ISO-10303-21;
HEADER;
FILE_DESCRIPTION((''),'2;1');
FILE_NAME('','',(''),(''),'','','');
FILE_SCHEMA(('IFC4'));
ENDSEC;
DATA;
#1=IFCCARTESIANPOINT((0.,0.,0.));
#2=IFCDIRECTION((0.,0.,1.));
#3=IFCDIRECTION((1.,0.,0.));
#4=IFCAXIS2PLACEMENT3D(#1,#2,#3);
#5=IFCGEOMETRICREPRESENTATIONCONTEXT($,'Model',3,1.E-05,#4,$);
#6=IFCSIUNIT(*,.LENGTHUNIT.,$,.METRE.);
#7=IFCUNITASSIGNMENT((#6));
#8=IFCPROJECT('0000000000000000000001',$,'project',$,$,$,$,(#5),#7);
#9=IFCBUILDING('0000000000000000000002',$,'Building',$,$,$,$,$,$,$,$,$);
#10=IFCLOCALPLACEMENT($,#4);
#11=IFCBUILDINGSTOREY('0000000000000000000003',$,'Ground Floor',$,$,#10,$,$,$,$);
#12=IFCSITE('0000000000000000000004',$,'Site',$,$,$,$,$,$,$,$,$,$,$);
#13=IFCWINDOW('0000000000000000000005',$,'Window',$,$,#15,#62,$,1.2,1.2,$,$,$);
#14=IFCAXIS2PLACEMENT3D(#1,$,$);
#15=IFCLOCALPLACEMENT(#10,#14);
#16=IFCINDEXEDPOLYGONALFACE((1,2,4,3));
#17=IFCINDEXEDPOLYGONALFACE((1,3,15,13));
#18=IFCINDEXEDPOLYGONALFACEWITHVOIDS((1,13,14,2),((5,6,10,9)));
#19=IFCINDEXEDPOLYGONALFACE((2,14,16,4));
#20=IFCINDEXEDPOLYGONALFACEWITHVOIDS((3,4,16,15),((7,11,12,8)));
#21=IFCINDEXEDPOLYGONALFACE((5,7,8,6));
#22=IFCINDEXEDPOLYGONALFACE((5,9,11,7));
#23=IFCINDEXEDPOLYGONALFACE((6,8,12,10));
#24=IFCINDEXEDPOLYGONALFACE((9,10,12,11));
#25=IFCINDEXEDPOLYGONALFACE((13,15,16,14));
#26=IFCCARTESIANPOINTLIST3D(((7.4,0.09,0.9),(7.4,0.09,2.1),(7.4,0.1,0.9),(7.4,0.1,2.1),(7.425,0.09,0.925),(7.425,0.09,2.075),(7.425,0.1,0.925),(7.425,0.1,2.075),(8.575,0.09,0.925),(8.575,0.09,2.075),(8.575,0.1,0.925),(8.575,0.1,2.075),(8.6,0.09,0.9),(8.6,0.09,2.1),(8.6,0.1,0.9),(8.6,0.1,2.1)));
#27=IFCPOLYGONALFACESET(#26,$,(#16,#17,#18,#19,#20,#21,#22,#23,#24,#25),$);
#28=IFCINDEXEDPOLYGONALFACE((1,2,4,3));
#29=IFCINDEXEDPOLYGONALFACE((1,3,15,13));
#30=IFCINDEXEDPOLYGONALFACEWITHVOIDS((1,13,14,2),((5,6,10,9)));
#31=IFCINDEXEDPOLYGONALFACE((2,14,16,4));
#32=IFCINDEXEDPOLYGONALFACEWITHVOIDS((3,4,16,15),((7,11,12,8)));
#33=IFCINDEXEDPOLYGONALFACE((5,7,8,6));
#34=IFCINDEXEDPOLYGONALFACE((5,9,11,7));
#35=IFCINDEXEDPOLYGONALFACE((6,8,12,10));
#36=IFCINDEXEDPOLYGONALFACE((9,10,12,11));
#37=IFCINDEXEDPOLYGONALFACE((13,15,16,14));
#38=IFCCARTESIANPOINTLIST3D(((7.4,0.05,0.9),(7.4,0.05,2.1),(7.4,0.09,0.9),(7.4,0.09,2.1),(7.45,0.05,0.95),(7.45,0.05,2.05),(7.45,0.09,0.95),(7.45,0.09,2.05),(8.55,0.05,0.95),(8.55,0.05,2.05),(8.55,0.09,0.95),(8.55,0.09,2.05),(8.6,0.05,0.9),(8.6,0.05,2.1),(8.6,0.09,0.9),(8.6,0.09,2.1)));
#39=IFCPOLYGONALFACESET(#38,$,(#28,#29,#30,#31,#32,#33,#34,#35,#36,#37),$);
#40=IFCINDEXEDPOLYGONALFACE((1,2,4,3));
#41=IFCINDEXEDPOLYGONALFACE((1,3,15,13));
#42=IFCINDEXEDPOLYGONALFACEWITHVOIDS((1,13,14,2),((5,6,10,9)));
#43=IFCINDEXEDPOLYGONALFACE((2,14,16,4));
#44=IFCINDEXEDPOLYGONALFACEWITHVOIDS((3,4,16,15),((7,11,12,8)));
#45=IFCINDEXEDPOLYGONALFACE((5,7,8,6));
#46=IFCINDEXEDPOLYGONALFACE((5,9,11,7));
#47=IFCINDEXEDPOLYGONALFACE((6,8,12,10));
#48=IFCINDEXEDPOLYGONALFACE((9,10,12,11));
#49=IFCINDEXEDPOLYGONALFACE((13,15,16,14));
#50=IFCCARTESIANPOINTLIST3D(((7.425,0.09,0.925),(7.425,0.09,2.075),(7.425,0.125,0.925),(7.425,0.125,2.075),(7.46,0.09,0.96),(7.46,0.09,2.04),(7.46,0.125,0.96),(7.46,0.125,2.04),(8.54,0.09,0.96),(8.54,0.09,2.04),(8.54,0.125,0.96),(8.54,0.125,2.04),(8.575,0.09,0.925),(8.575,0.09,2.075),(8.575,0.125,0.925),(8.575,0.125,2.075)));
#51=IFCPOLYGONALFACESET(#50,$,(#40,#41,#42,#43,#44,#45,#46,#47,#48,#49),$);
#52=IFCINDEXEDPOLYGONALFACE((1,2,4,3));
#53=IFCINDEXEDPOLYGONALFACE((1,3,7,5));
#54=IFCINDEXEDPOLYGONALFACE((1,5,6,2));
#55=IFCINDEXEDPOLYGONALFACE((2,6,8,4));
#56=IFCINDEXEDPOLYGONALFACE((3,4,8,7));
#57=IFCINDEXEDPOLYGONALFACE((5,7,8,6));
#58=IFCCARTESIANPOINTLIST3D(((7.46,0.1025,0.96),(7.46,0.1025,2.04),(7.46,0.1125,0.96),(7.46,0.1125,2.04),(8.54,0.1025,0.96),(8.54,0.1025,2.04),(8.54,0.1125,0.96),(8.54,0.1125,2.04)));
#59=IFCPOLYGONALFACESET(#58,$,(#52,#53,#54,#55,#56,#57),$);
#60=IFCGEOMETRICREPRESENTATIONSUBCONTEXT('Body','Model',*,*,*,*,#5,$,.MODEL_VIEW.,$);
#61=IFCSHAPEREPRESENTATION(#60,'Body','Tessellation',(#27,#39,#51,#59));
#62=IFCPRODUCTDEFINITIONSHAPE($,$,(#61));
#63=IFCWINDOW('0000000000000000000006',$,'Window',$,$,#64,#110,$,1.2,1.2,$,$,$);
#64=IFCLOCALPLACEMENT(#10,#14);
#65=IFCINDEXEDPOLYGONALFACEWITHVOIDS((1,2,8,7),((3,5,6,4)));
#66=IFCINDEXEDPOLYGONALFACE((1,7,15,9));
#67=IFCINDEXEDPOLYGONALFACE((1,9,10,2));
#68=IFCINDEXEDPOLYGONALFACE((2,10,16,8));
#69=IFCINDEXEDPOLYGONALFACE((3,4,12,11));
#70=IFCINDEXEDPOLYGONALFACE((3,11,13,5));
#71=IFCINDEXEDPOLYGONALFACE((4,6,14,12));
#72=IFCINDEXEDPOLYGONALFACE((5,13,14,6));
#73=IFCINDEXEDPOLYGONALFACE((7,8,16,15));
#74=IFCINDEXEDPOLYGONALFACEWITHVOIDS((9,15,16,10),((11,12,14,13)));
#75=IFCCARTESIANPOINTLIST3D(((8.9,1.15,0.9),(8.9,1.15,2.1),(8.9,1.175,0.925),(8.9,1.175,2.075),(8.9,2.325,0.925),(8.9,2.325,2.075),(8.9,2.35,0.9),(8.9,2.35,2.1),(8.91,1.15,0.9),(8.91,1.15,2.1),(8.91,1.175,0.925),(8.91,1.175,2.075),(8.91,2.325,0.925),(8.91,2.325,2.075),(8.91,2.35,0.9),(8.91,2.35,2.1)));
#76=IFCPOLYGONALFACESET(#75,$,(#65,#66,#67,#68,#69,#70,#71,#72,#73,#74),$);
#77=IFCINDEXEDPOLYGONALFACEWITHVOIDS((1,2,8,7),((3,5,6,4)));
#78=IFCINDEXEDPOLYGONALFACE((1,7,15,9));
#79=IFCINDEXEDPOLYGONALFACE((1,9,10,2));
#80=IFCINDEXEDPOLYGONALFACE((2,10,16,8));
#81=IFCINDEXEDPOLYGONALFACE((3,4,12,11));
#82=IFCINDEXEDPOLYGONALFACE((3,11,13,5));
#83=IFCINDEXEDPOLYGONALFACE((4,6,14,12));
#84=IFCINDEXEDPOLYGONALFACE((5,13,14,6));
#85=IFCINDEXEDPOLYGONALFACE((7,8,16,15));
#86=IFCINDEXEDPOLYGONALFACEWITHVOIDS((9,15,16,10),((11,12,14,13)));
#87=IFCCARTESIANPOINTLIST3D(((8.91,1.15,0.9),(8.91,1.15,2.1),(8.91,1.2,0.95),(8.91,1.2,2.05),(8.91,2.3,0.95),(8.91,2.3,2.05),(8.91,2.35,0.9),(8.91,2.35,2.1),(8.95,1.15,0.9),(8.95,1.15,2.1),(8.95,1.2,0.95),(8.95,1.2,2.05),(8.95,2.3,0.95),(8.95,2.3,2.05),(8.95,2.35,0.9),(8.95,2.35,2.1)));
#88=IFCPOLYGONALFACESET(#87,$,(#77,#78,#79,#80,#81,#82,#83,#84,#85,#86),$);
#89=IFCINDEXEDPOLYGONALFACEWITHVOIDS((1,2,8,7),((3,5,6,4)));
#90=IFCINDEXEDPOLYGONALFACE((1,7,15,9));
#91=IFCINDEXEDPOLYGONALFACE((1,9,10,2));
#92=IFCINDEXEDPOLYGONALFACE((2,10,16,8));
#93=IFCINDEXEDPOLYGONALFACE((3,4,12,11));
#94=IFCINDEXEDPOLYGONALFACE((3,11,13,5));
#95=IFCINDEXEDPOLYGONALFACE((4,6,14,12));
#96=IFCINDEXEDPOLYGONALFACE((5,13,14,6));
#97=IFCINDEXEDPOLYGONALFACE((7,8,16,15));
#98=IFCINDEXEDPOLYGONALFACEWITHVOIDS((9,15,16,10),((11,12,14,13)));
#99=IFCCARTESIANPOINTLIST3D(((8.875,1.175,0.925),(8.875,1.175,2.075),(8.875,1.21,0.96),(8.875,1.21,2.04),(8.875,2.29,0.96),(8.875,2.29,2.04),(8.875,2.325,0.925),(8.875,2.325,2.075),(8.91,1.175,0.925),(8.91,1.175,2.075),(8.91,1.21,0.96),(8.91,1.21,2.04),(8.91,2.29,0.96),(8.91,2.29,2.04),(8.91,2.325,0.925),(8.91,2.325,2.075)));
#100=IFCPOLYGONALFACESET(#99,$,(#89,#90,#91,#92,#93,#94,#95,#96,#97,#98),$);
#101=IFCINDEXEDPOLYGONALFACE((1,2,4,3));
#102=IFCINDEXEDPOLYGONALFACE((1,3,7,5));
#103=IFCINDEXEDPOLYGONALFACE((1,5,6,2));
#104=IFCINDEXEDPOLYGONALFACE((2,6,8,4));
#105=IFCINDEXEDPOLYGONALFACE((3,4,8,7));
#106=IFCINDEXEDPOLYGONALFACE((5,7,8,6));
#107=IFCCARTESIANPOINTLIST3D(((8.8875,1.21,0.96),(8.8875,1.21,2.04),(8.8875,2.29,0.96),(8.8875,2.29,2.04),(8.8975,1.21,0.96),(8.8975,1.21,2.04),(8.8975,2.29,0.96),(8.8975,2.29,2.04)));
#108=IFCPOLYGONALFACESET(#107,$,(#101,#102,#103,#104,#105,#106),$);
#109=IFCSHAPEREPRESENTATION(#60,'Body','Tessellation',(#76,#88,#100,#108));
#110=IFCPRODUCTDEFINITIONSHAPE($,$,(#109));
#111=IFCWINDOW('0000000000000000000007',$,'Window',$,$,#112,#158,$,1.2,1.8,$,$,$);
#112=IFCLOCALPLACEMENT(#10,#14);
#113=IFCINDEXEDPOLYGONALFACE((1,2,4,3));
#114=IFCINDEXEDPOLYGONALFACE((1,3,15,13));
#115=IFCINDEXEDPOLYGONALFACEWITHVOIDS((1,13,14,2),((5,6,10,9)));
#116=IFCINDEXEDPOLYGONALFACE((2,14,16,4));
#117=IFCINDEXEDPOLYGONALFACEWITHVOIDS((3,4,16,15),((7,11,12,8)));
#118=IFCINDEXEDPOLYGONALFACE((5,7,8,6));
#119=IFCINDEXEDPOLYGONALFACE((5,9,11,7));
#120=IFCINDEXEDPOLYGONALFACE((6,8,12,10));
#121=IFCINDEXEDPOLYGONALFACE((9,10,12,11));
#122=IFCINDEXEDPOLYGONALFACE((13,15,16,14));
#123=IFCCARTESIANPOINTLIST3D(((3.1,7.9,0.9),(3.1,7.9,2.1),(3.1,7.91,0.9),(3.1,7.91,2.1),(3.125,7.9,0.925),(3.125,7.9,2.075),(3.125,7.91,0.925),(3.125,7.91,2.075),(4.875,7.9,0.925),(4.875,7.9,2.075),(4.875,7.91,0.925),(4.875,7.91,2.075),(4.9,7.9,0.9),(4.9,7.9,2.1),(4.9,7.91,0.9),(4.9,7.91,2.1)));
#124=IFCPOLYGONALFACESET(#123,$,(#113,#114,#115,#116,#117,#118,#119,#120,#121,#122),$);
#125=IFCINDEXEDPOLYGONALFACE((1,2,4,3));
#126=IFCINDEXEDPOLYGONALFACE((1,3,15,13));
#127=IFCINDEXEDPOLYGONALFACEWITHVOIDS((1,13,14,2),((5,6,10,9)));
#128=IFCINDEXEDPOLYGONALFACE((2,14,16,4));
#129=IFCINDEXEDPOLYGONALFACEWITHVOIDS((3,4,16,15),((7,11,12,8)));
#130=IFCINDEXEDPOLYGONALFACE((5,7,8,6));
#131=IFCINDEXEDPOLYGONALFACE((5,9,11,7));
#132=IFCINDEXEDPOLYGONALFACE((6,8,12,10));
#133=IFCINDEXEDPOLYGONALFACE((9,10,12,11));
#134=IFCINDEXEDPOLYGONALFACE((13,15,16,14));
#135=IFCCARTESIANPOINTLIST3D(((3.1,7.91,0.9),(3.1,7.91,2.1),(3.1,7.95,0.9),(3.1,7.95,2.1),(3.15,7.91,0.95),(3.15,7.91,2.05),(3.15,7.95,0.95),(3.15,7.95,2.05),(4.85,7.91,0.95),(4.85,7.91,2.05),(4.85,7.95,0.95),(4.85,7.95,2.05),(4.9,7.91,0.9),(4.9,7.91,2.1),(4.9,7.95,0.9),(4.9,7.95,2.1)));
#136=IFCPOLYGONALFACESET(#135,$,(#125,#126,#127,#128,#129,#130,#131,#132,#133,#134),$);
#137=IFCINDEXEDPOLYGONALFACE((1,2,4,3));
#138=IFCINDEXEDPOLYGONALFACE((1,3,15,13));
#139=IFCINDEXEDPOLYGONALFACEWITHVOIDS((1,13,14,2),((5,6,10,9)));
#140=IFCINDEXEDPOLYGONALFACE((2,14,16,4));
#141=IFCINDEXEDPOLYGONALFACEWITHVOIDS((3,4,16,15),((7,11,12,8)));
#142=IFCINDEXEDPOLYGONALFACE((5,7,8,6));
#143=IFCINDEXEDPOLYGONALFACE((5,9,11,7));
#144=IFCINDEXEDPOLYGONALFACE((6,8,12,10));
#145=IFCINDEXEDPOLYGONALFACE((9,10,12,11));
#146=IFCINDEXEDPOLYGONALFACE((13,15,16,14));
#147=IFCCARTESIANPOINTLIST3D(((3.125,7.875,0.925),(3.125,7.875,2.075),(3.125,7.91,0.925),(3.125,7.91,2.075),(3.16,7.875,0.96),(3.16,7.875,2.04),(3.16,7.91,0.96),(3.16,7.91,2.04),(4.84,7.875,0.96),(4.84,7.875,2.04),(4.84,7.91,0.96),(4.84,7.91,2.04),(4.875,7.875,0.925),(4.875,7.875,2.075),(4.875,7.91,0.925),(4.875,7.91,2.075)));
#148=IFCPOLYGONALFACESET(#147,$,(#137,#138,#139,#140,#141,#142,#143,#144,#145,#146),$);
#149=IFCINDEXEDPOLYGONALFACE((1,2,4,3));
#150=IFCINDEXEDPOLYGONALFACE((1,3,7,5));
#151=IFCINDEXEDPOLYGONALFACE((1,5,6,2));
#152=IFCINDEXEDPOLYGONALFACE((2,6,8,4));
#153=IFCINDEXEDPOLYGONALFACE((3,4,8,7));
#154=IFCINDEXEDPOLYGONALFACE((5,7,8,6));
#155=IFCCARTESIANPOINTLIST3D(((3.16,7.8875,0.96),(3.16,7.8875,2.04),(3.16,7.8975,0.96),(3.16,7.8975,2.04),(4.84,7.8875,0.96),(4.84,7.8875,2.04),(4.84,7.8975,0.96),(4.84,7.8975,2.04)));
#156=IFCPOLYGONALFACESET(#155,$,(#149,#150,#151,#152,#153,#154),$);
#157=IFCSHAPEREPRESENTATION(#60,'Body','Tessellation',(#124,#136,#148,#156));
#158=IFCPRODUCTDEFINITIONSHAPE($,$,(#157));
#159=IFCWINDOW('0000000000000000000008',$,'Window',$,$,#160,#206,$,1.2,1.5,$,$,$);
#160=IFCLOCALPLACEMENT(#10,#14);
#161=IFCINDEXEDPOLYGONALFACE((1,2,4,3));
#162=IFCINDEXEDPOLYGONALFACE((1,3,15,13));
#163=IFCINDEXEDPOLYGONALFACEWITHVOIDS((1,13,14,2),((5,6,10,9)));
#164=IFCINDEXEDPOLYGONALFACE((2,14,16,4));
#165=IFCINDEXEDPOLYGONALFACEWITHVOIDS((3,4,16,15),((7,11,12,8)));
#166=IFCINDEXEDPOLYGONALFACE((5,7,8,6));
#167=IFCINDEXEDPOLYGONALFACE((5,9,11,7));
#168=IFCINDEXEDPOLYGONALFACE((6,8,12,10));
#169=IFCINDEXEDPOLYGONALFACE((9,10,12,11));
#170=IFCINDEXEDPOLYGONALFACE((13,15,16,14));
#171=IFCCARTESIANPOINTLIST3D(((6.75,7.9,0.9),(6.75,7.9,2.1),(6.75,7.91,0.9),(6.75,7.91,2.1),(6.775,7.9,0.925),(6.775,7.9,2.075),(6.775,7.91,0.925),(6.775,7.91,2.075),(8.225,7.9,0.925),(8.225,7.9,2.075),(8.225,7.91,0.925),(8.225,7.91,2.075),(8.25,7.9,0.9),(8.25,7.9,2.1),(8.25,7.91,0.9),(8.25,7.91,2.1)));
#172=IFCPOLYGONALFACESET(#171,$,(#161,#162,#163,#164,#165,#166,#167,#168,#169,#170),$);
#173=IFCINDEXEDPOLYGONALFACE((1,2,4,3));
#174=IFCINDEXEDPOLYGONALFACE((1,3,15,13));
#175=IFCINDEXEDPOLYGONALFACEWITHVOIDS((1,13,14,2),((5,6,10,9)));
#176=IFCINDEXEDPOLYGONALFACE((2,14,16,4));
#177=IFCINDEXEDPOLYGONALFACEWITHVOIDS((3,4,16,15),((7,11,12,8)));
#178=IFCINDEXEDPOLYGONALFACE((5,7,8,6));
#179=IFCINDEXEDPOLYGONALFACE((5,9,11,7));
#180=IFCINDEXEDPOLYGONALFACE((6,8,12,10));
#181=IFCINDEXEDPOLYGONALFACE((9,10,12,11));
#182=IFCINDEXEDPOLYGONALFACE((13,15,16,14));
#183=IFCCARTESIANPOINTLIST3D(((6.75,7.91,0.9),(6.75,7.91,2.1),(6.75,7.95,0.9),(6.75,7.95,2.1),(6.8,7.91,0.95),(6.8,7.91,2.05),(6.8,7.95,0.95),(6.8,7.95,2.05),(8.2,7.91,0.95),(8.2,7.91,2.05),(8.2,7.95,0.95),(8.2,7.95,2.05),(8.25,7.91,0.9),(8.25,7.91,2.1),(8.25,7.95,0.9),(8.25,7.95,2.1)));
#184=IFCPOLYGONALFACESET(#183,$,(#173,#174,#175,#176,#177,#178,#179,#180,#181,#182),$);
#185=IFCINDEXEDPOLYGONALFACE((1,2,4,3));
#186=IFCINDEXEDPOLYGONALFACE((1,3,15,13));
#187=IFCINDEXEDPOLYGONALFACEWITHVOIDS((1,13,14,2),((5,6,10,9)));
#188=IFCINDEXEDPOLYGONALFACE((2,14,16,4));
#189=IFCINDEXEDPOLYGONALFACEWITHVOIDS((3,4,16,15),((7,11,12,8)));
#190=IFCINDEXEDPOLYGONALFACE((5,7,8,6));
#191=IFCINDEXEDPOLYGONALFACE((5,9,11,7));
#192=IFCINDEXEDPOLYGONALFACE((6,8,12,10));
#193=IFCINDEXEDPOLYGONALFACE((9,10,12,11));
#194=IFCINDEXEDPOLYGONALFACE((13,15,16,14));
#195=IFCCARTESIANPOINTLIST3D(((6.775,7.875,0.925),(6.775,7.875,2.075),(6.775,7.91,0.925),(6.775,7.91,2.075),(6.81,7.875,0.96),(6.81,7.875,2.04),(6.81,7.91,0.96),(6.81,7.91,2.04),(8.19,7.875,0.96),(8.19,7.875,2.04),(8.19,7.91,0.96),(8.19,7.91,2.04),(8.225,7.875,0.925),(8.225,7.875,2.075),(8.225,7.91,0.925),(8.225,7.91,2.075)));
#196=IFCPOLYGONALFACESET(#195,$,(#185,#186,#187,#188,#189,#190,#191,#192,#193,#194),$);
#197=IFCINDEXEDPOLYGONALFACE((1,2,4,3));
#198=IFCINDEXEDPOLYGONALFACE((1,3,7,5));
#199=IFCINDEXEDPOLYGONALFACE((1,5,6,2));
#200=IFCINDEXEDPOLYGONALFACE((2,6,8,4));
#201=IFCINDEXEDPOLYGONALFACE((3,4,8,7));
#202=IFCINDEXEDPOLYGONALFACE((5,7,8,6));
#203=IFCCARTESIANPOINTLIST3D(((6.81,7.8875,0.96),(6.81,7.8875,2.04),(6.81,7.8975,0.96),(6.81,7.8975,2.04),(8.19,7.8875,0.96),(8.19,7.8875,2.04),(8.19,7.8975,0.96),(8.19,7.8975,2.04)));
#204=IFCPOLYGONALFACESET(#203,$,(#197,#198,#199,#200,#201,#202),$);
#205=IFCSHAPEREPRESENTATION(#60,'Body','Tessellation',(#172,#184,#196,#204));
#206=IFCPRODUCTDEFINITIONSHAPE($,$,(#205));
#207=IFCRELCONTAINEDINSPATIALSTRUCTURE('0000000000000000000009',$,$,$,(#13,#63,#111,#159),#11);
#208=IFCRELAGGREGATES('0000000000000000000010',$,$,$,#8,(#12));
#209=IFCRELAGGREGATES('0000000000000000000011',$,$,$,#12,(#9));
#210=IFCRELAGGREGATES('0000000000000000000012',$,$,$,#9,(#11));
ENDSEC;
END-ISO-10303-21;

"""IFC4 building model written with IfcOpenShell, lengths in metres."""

from ifc_helpers import new_model, si_unit, frame, origin_with_axes, place, context, subcontext, project, spatial, line, indexed_curve, outline, extrude, element, save


model = new_model("IFC4")

# Units and contexts
model_context = context("Model", 3, precision=1e-05, world=origin_with_axes())
body_context = subcontext(model_context, "Body", "Model", "MODEL_VIEW")
ifc_project = project(units=[si_unit("LENGTHUNIT", "METRE")], contexts=[model_context])

# Site, building, storey
site = spatial("IfcSite", under=ifc_project, Name="Site")
building = spatial("IfcBuilding", under=site, Name="Building")
storey_placement = place(None, origin_with_axes())
storey = spatial("IfcBuildingStorey", under=building, at=storey_placement, Name="Ground Floor")

# Windows
for number, where, z_axis, x_axis, name in (
    (1, (7.4, 0.0, 0.9), (0.0, 0.0, 1.0), (1.0, 0.0, 0.0), "Window"),
    (2, (9.0, 1.15, 0.9), (0.0, 0.0, 1.0), (0.0, 1.0, 0.0), "Window"),
):
    element("IfcWindow", number, at=place(storey_placement, frame(where, z_axis=z_axis, x_axis=x_axis)), inside=storey, Name=name, OverallHeight=1.2, OverallWidth=1.2, context=body_context, shape_type="SweptSolid", body=[
        extrude(outline(indexed_curve([(0.0, 0.0), (1.2, 0.0), (1.2, 1.2), (0.0, 1.2)], segments=[line(1, 2, 3, 4, 1)]), holes=[indexed_curve([(0.025, 0.025), (1.175, 0.025), (1.175, 1.175), (0.025, 1.175)], segments=[line(1, 2, 3, 4, 1)])]), frame((0.0, 0.09, 0.0), z_axis=(0.0, -1.0, 0.0), x_axis=(1.0, 0.0, 0.0)), (0.0, 0.0, -1.0), 0.01),
        extrude(outline(indexed_curve([(0.0, 0.0), (1.2, 0.0), (1.2, 1.2), (0.0, 1.2)], segments=[line(1, 2, 3, 4, 1)]), holes=[indexed_curve([(0.05, 0.05), (1.15, 0.05), (1.15, 1.15), (0.05, 1.15)], segments=[line(1, 2, 3, 4, 1)])]), frame((0.0, 0.05, 0.0), z_axis=(0.0, -1.0, 0.0), x_axis=(1.0, 0.0, 0.0)), (0.0, 0.0, -1.0), 0.04),
        extrude(outline(indexed_curve([(0.0, 0.0), (1.15, 0.0), (1.15, 1.15), (0.0, 1.15)], segments=[line(1, 2, 3, 4, 1)]), holes=[indexed_curve([(0.035, 0.035), (1.115, 0.035), (1.115, 1.115), (0.035, 1.115)], segments=[line(1, 2, 3, 4, 1)])]), frame((0.025, 0.09, 0.025), z_axis=(0.0, -1.0, 0.0), x_axis=(1.0, 0.0, 0.0)), (0.0, 0.0, -1.0), 0.035),
        extrude(outline(indexed_curve([(0.035, 0.035), (1.115, 0.035), (1.115, 1.115), (0.035, 1.115)], segments=[line(1, 2, 3, 4, 1)])), frame((0.025, 0.1025, 0.025), z_axis=(0.0, -1.0, 0.0), x_axis=(1.0, 0.0, 0.0)), (0.0, 0.0, -1.0), 0.01),
    ])
window_placement = place(storey_placement, frame((4.9, 8.0, 0.9), z_axis=(0.0, 0.0, 1.0), x_axis=(-1.0, 0.0, 0.0)))
element("IfcWindow", 3, at=window_placement, inside=storey, Name="Window", OverallHeight=1.2, OverallWidth=1.8, context=body_context, shape_type="SweptSolid", body=[
    extrude(outline(indexed_curve([(0.0, 0.0), (1.8, 0.0), (1.8, 1.2), (0.0, 1.2)], segments=[line(1, 2, 3, 4, 1)]), holes=[indexed_curve([(0.025, 0.025), (1.775, 0.025), (1.775, 1.175), (0.025, 1.175)], segments=[line(1, 2, 3, 4, 1)])]), frame((0.0, 0.09, 0.0), z_axis=(0.0, -1.0, 0.0), x_axis=(1.0, 0.0, 0.0)), (0.0, 0.0, -1.0), 0.01),
    extrude(outline(indexed_curve([(0.0, 0.0), (1.8, 0.0), (1.8, 1.2), (0.0, 1.2)], segments=[line(1, 2, 3, 4, 1)]), holes=[indexed_curve([(0.05, 0.05), (1.75, 0.05), (1.75, 1.15), (0.05, 1.15)], segments=[line(1, 2, 3, 4, 1)])]), frame((0.0, 0.05, 0.0), z_axis=(0.0, -1.0, 0.0), x_axis=(1.0, 0.0, 0.0)), (0.0, 0.0, -1.0), 0.04),
    extrude(outline(indexed_curve([(0.0, 0.0), (1.75, 0.0), (1.75, 1.15), (0.0, 1.15)], segments=[line(1, 2, 3, 4, 1)]), holes=[indexed_curve([(0.035, 0.035), (1.715, 0.035), (1.715, 1.115), (0.035, 1.115)], segments=[line(1, 2, 3, 4, 1)])]), frame((0.025, 0.09, 0.025), z_axis=(0.0, -1.0, 0.0), x_axis=(1.0, 0.0, 0.0)), (0.0, 0.0, -1.0), 0.035),
    extrude(outline(indexed_curve([(0.035, 0.035), (1.715, 0.035), (1.715, 1.115), (0.035, 1.115)], segments=[line(1, 2, 3, 4, 1)])), frame((0.025, 0.1025, 0.025), z_axis=(0.0, -1.0, 0.0), x_axis=(1.0, 0.0, 0.0)), (0.0, 0.0, -1.0), 0.01),
])
for number, where, z_axis, x_axis, name in (
    (4, (8.25, 8.0, 0.9), (0.0, 0.0, 1.0), (-1.0, 0.0, 0.0), "Window"),
):
    element("IfcWindow", number, at=place(storey_placement, frame(where, z_axis=z_axis, x_axis=x_axis)), inside=storey, Name=name, OverallHeight=1.2, OverallWidth=1.5, context=body_context, shape_type="SweptSolid", body=[
        extrude(outline(indexed_curve([(0.0, 0.0), (1.5, 0.0), (1.5, 1.2), (0.0, 1.2)], segments=[line(1, 2, 3, 4, 1)]), holes=[indexed_curve([(0.025, 0.025), (1.475, 0.025), (1.475, 1.175), (0.025, 1.175)], segments=[line(1, 2, 3, 4, 1)])]), frame((0.0, 0.09, 0.0), z_axis=(0.0, -1.0, 0.0), x_axis=(1.0, 0.0, 0.0)), (0.0, 0.0, -1.0), 0.01),
        extrude(outline(indexed_curve([(0.0, 0.0), (1.5, 0.0), (1.5, 1.2), (0.0, 1.2)], segments=[line(1, 2, 3, 4, 1)]), holes=[indexed_curve([(0.05, 0.05), (1.45, 0.05), (1.45, 1.15), (0.05, 1.15)], segments=[line(1, 2, 3, 4, 1)])]), frame((0.0, 0.05, 0.0), z_axis=(0.0, -1.0, 0.0), x_axis=(1.0, 0.0, 0.0)), (0.0, 0.0, -1.0), 0.04),
        extrude(outline(indexed_curve([(0.0, 0.0), (1.45, 0.0), (1.45, 1.15), (0.0, 1.15)], segments=[line(1, 2, 3, 4, 1)]), holes=[indexed_curve([(0.035, 0.035), (1.415, 0.035), (1.415, 1.115), (0.035, 1.115)], segments=[line(1, 2, 3, 4, 1)])]), frame((0.025, 0.09, 0.025), z_axis=(0.0, -1.0, 0.0), x_axis=(1.0, 0.0, 0.0)), (0.0, 0.0, -1.0), 0.035),
        extrude(outline(indexed_curve([(0.035, 0.035), (1.415, 0.035), (1.415, 1.115), (0.035, 1.115)], segments=[line(1, 2, 3, 4, 1)])), frame((0.025, 0.1025, 0.025), z_axis=(0.0, -1.0, 0.0), x_axis=(1.0, 0.0, 0.0)), (0.0, 0.0, -1.0), 0.01),
    ])

save(model, "model.ifc")
